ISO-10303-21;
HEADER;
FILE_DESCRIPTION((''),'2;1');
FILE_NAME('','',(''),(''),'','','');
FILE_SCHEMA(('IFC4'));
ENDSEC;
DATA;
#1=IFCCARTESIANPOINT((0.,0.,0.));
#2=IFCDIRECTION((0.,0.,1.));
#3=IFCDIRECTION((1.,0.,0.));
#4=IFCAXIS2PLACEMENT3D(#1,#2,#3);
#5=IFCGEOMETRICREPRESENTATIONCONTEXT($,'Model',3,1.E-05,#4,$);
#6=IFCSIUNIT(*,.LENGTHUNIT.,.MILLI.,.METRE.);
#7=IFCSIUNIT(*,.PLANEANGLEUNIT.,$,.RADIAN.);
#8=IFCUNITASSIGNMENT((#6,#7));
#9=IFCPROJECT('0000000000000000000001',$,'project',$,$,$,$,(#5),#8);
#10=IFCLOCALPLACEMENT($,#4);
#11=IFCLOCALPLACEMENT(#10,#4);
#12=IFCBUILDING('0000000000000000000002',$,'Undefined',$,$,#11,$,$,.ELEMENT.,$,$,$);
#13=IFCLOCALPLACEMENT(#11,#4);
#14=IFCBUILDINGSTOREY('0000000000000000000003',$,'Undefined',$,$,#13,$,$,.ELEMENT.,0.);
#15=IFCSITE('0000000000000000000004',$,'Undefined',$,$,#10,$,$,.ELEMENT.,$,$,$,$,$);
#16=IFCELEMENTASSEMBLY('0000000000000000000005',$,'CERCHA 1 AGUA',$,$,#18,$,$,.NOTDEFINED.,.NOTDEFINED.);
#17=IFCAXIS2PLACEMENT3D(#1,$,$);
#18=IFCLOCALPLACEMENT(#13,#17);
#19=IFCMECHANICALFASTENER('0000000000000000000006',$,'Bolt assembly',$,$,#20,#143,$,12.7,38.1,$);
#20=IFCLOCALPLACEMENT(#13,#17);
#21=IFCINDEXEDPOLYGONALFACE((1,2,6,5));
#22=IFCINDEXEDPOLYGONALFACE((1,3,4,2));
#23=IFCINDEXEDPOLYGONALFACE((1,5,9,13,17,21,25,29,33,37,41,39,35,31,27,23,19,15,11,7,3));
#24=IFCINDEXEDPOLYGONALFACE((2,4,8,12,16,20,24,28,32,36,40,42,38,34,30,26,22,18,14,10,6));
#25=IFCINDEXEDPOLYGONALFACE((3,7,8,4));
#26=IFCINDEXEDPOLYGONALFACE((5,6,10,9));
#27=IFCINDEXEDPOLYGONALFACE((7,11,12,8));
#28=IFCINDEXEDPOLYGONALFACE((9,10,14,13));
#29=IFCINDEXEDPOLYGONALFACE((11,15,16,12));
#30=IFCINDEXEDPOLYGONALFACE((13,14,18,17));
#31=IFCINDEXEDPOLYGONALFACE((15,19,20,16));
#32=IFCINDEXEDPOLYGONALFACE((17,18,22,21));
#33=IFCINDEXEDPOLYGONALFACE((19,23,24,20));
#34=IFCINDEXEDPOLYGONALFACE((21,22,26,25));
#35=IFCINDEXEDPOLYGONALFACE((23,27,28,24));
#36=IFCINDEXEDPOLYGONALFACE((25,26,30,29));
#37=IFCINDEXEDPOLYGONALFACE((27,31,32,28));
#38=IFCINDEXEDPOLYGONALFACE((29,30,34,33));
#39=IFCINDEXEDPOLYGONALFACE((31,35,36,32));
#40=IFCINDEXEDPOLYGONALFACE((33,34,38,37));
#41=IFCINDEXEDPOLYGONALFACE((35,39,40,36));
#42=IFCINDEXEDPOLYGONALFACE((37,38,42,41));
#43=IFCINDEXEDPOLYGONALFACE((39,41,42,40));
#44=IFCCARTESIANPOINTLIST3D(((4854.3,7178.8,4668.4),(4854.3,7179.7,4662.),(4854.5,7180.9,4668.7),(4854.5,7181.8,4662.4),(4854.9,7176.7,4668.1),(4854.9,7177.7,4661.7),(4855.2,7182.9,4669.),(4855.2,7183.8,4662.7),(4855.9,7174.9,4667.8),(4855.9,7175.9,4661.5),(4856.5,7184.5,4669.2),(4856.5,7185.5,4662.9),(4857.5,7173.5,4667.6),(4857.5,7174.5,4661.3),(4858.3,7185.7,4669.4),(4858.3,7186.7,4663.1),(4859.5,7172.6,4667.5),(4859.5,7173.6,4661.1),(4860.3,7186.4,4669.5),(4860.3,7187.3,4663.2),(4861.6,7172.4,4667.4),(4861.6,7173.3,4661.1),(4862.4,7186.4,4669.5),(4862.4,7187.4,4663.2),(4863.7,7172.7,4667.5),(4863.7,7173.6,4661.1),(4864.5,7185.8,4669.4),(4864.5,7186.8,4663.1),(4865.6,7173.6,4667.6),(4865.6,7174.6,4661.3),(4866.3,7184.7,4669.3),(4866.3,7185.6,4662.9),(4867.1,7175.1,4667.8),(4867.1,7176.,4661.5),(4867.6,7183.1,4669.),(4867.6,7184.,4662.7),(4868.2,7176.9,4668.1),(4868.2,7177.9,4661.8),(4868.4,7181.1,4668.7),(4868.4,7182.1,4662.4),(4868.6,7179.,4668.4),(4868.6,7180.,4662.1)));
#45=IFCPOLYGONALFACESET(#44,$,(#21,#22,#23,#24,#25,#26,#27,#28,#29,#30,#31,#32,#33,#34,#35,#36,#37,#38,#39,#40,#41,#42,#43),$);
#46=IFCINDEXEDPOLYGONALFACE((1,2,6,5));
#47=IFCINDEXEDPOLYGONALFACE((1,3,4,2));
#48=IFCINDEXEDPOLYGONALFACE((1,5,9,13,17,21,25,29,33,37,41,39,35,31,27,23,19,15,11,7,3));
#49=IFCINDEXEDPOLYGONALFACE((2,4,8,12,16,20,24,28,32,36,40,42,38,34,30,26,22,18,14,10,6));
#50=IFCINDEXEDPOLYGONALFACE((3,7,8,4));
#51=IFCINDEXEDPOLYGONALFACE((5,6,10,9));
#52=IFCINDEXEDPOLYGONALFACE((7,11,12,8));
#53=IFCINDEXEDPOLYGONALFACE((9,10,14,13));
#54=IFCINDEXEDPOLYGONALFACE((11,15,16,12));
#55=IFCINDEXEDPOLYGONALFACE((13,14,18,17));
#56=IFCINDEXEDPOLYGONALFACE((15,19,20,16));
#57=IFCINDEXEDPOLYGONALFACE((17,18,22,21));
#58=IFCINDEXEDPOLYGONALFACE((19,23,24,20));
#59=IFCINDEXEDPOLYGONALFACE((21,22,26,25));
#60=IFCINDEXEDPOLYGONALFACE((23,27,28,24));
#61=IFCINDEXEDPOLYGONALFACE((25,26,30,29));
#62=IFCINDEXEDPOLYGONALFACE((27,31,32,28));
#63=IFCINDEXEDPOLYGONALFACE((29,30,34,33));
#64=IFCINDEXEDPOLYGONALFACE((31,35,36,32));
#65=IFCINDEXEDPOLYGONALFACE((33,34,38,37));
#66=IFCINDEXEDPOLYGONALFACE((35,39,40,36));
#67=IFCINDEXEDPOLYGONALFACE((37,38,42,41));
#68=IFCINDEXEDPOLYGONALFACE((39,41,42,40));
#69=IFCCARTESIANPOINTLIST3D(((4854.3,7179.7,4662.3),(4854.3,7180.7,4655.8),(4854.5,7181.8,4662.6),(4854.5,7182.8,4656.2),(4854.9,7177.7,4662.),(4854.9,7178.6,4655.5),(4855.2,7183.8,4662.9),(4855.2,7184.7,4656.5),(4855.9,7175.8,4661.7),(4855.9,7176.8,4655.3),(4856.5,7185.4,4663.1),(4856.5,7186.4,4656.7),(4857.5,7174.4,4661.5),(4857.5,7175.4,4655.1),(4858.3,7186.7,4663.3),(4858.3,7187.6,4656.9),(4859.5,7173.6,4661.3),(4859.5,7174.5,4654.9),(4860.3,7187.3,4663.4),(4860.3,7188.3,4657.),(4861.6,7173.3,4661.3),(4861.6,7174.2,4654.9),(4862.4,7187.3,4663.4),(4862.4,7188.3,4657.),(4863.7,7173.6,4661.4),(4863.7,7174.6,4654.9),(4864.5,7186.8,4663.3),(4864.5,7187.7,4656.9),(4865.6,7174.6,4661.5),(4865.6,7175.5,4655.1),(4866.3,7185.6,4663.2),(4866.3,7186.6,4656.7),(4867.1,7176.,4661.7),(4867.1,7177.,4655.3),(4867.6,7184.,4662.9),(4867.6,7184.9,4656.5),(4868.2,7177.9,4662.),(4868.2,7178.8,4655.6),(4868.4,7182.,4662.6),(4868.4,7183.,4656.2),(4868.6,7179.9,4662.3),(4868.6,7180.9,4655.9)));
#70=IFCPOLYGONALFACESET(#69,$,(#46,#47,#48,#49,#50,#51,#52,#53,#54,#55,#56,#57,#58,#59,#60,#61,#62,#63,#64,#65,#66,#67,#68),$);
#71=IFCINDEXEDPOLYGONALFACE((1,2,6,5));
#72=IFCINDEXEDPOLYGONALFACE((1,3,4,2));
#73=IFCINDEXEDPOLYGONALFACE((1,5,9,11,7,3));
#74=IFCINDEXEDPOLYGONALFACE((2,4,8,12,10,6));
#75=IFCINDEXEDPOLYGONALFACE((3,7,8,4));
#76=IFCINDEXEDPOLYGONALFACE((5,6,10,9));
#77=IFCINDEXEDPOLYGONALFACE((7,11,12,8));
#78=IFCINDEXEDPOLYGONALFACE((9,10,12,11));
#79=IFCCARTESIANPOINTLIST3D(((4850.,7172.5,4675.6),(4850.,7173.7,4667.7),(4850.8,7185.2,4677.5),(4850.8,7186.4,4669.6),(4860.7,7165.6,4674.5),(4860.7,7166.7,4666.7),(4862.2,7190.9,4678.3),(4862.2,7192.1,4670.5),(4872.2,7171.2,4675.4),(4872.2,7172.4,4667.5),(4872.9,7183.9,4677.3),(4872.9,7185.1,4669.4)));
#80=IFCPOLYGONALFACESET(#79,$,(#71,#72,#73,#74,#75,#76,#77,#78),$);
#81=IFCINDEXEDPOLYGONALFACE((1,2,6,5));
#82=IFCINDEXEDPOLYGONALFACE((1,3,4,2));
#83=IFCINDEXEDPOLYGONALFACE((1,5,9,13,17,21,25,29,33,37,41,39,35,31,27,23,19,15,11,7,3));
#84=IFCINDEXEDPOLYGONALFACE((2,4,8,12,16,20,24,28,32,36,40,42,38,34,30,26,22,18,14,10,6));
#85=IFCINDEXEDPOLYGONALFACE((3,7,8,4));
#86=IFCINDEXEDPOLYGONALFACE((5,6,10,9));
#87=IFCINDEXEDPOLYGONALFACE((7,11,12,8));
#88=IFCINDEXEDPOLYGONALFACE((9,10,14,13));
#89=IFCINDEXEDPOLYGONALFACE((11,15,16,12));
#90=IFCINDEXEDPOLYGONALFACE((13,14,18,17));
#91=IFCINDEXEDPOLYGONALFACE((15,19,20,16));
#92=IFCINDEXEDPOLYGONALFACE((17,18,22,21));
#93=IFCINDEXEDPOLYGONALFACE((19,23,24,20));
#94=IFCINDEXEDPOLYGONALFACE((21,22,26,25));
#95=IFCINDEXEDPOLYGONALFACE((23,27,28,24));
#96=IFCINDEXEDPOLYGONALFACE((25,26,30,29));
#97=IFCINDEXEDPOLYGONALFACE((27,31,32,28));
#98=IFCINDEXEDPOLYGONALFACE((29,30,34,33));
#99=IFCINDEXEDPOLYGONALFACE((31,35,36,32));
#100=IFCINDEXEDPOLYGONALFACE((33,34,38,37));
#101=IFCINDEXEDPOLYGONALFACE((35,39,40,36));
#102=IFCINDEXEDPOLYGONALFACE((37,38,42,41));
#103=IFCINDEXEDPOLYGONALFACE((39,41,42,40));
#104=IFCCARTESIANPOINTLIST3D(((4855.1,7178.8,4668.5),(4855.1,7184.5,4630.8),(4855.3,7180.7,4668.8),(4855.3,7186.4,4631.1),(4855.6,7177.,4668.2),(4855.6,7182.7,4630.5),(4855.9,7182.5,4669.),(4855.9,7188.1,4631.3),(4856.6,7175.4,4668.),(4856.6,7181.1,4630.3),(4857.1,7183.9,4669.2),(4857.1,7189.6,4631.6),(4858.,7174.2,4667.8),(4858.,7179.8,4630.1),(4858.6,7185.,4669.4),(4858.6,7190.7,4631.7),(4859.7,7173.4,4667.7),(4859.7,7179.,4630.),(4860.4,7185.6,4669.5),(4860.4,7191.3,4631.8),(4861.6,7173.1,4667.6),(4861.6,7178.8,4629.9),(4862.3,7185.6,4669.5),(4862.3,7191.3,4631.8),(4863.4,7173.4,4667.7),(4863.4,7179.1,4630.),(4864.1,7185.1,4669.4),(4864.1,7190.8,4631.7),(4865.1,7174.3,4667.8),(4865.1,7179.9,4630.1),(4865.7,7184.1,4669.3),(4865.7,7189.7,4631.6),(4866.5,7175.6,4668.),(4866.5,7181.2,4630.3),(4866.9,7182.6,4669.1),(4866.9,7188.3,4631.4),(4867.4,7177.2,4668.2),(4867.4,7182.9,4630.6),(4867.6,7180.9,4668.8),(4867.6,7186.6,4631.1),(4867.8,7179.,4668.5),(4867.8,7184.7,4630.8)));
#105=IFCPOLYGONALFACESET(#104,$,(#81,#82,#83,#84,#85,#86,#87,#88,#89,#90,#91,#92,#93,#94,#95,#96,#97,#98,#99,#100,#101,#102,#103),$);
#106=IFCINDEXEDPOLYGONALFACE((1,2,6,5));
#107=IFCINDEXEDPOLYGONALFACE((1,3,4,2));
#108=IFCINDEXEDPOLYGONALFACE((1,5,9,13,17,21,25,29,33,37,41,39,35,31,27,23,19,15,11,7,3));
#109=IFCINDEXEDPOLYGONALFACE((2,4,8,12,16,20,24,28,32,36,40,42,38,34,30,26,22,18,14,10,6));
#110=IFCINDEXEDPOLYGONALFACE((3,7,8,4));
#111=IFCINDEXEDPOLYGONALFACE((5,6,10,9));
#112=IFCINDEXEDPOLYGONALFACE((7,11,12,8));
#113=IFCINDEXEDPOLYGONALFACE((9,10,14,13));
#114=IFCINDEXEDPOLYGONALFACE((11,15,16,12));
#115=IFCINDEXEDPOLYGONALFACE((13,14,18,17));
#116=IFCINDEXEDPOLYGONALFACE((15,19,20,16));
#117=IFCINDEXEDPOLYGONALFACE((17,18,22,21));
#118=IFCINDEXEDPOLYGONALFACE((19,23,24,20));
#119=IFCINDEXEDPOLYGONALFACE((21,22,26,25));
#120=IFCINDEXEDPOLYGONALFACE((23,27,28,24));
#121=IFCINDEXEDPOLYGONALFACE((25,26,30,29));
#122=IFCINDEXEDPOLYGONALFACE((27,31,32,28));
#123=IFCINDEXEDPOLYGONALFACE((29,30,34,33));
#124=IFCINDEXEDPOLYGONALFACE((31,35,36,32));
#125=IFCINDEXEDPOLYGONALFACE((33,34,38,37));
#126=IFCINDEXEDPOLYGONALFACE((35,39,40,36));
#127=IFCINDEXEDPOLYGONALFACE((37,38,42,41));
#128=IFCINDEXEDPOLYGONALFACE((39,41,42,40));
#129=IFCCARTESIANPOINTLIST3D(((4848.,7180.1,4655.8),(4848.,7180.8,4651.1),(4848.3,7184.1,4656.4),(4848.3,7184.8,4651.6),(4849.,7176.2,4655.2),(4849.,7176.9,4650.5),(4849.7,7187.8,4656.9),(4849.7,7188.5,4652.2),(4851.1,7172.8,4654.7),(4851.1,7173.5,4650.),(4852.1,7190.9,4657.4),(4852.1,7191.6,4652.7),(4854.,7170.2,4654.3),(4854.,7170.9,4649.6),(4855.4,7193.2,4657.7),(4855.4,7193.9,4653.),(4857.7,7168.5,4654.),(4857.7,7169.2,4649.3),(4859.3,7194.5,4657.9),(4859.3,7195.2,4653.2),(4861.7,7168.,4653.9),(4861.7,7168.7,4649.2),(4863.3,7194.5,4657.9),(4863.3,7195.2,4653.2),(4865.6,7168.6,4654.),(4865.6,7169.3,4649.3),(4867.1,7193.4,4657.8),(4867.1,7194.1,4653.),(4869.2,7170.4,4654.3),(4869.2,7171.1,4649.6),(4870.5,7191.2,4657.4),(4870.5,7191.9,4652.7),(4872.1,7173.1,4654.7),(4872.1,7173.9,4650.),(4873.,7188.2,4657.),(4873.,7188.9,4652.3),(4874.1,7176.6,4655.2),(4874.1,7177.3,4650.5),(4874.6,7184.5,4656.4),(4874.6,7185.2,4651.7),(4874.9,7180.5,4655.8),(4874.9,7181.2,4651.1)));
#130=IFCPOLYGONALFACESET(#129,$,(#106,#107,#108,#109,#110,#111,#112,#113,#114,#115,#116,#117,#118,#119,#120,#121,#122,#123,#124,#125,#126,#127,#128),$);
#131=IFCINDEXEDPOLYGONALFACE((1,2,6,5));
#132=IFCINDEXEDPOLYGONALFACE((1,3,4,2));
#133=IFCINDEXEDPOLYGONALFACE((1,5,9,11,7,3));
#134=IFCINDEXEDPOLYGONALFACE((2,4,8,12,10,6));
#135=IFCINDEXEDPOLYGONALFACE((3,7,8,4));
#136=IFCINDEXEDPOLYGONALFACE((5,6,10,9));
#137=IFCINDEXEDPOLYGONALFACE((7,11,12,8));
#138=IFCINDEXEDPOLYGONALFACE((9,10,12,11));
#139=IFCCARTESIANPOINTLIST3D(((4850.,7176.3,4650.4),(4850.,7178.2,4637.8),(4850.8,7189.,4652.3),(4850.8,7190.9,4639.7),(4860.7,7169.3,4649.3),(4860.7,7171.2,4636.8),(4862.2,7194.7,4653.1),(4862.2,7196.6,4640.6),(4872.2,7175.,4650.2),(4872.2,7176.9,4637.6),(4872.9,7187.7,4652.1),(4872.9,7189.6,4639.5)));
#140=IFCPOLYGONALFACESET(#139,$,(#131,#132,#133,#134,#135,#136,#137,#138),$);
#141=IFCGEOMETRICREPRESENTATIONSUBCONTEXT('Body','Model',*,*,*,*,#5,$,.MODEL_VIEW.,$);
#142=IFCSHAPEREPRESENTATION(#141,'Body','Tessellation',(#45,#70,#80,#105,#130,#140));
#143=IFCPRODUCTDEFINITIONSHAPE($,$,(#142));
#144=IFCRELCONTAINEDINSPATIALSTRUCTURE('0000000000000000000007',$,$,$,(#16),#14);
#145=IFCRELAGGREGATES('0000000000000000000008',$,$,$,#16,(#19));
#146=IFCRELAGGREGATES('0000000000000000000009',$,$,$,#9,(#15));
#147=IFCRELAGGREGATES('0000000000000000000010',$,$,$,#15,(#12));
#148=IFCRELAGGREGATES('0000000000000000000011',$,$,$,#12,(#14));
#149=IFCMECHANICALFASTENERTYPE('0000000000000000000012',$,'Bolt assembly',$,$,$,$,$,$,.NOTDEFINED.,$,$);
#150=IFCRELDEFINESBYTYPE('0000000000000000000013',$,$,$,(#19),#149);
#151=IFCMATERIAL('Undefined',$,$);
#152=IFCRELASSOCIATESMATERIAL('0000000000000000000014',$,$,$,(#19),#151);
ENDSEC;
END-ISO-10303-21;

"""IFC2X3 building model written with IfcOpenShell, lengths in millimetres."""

from ifc_helpers import new_model, si_unit, frame, origin_with_axes, origin_2d_with_axis, place, context, subcontext, project, spatial, polyline, circle, outline, extrude, source, transform, mapped, material, type_object, element, aggregate, save


model = new_model("IFC2X3")

# Units and contexts
model_context = context("Model", 3, precision=1e-05, world=origin_with_axes())
body_context = subcontext(model_context, "Body", "Model", "MODEL_VIEW")
ifc_project = project(units=[si_unit("LENGTHUNIT", "METRE", prefix="MILLI"), si_unit("PLANEANGLEUNIT", "RADIAN")], contexts=[model_context])

# Site, building, storey
site_placement = place(None, origin_with_axes())
site = spatial("IfcSite", under=ifc_project, at=site_placement, Name="Undefined", CompositionType="ELEMENT")
building_placement = place(site_placement, origin_with_axes())
building = spatial("IfcBuilding", under=site, at=building_placement, Name="Undefined", CompositionType="ELEMENT")
storey_placement = place(building_placement, origin_with_axes())
storey = spatial("IfcBuildingStorey", under=building, at=storey_placement, Name="Undefined", CompositionType="ELEMENT", Elevation=0.0)

# Element assembly
assembly_1_placement = place(storey_placement, origin_with_axes())
assembly_1 = element("IfcElementAssembly", 1, at=assembly_1_placement, inside=storey, Name="CERCHA 1 AGUA", AssemblyPlace="NOTDEFINED", PredefinedType="NOTDEFINED")

# Shared definitions
ifc_material_1 = material(Name="Undefined")
mechanical_fastener_type = type_object("IfcMechanicalFastenerType", Name="Bolt assembly")

# Mechanical fastener
shared_shape_1 = source(origin_with_axes(), body_context, "Body", "SweptSolid", [
    extrude(circle(Radius=7.1, at=origin_2d_with_axis()), frame((0.0, -6.3, 0.0), z_axis=(0.0, 1.0, 0.0), x_axis=(1.0, 0.0, 0.0)), (0.0, 0.0, 1.0), 6.4),
    extrude(circle(Radius=7.1, at=origin_2d_with_axis()), frame((0.0, -0.1, 0.0), z_axis=(0.0, 1.0, 0.0), x_axis=(1.0, 0.0, 0.0)), (0.0, 0.0, 1.0), 6.5),
    extrude(outline(polyline([(11.1, -6.4), (11.1, 6.4), (0.0, 12.8), (-11.1, 6.4), (-11.1, -6.4), (0.0, -12.8), (11.1, -6.4)])), frame((0.0, -14.3, 0.0), z_axis=(0.0, 1.0, 0.0), x_axis=(1.0, 0.0, 0.0)), (0.0, 0.0, 1.0), 7.9),
    extrude(circle(Radius=6.3, at=origin_2d_with_axis()), frame((0.0, -6.4, 0.0), z_axis=(0.0, 1.0, 0.0), x_axis=(1.0, 0.0, 0.0)), (0.0, 0.0, 1.0), 38.1),
    extrude(circle(Radius=13.5, at=origin_2d_with_axis()), frame((0.0, 6.4, 0.0), z_axis=(0.0, 1.0, 0.0), x_axis=(1.0, 0.0, 0.0)), (0.0, 0.0, 1.0), 4.8),
    extrude(outline(polyline([(11.1, -6.4), (11.1, 6.4), (0.0, 12.8), (-11.1, 6.4), (-11.1, -6.4), (0.0, -12.8), (11.1, -6.4)])), frame((0.0, 11.2, 0.0), z_axis=(0.0, 1.0, 0.0), x_axis=(1.0, 0.0, 0.0)), (0.0, 0.0, 1.0), 12.7),
])
mechanical_fastener_1_placement = place(assembly_1_placement, frame((4861.5, 7180.4, 4662.3), z_axis=(0.834881, -0.544341, -0.081651), x_axis=(-0.55043, -0.825644, -0.123847)))
mechanical_fastener_1 = element("IfcMechanicalFastener", 2, at=mechanical_fastener_1_placement, type_object=mechanical_fastener_type, material=ifc_material_1, Name="Bolt assembly", NominalDiameter=12.7, NominalLength=38.1, context=body_context, shape_type="MappedRepresentation", body=[
    mapped(shared_shape_1, transform((0.0, 0.0, 0.0))),
])
aggregate(assembly_1, [mechanical_fastener_1])

save(model, "model.ifc")
